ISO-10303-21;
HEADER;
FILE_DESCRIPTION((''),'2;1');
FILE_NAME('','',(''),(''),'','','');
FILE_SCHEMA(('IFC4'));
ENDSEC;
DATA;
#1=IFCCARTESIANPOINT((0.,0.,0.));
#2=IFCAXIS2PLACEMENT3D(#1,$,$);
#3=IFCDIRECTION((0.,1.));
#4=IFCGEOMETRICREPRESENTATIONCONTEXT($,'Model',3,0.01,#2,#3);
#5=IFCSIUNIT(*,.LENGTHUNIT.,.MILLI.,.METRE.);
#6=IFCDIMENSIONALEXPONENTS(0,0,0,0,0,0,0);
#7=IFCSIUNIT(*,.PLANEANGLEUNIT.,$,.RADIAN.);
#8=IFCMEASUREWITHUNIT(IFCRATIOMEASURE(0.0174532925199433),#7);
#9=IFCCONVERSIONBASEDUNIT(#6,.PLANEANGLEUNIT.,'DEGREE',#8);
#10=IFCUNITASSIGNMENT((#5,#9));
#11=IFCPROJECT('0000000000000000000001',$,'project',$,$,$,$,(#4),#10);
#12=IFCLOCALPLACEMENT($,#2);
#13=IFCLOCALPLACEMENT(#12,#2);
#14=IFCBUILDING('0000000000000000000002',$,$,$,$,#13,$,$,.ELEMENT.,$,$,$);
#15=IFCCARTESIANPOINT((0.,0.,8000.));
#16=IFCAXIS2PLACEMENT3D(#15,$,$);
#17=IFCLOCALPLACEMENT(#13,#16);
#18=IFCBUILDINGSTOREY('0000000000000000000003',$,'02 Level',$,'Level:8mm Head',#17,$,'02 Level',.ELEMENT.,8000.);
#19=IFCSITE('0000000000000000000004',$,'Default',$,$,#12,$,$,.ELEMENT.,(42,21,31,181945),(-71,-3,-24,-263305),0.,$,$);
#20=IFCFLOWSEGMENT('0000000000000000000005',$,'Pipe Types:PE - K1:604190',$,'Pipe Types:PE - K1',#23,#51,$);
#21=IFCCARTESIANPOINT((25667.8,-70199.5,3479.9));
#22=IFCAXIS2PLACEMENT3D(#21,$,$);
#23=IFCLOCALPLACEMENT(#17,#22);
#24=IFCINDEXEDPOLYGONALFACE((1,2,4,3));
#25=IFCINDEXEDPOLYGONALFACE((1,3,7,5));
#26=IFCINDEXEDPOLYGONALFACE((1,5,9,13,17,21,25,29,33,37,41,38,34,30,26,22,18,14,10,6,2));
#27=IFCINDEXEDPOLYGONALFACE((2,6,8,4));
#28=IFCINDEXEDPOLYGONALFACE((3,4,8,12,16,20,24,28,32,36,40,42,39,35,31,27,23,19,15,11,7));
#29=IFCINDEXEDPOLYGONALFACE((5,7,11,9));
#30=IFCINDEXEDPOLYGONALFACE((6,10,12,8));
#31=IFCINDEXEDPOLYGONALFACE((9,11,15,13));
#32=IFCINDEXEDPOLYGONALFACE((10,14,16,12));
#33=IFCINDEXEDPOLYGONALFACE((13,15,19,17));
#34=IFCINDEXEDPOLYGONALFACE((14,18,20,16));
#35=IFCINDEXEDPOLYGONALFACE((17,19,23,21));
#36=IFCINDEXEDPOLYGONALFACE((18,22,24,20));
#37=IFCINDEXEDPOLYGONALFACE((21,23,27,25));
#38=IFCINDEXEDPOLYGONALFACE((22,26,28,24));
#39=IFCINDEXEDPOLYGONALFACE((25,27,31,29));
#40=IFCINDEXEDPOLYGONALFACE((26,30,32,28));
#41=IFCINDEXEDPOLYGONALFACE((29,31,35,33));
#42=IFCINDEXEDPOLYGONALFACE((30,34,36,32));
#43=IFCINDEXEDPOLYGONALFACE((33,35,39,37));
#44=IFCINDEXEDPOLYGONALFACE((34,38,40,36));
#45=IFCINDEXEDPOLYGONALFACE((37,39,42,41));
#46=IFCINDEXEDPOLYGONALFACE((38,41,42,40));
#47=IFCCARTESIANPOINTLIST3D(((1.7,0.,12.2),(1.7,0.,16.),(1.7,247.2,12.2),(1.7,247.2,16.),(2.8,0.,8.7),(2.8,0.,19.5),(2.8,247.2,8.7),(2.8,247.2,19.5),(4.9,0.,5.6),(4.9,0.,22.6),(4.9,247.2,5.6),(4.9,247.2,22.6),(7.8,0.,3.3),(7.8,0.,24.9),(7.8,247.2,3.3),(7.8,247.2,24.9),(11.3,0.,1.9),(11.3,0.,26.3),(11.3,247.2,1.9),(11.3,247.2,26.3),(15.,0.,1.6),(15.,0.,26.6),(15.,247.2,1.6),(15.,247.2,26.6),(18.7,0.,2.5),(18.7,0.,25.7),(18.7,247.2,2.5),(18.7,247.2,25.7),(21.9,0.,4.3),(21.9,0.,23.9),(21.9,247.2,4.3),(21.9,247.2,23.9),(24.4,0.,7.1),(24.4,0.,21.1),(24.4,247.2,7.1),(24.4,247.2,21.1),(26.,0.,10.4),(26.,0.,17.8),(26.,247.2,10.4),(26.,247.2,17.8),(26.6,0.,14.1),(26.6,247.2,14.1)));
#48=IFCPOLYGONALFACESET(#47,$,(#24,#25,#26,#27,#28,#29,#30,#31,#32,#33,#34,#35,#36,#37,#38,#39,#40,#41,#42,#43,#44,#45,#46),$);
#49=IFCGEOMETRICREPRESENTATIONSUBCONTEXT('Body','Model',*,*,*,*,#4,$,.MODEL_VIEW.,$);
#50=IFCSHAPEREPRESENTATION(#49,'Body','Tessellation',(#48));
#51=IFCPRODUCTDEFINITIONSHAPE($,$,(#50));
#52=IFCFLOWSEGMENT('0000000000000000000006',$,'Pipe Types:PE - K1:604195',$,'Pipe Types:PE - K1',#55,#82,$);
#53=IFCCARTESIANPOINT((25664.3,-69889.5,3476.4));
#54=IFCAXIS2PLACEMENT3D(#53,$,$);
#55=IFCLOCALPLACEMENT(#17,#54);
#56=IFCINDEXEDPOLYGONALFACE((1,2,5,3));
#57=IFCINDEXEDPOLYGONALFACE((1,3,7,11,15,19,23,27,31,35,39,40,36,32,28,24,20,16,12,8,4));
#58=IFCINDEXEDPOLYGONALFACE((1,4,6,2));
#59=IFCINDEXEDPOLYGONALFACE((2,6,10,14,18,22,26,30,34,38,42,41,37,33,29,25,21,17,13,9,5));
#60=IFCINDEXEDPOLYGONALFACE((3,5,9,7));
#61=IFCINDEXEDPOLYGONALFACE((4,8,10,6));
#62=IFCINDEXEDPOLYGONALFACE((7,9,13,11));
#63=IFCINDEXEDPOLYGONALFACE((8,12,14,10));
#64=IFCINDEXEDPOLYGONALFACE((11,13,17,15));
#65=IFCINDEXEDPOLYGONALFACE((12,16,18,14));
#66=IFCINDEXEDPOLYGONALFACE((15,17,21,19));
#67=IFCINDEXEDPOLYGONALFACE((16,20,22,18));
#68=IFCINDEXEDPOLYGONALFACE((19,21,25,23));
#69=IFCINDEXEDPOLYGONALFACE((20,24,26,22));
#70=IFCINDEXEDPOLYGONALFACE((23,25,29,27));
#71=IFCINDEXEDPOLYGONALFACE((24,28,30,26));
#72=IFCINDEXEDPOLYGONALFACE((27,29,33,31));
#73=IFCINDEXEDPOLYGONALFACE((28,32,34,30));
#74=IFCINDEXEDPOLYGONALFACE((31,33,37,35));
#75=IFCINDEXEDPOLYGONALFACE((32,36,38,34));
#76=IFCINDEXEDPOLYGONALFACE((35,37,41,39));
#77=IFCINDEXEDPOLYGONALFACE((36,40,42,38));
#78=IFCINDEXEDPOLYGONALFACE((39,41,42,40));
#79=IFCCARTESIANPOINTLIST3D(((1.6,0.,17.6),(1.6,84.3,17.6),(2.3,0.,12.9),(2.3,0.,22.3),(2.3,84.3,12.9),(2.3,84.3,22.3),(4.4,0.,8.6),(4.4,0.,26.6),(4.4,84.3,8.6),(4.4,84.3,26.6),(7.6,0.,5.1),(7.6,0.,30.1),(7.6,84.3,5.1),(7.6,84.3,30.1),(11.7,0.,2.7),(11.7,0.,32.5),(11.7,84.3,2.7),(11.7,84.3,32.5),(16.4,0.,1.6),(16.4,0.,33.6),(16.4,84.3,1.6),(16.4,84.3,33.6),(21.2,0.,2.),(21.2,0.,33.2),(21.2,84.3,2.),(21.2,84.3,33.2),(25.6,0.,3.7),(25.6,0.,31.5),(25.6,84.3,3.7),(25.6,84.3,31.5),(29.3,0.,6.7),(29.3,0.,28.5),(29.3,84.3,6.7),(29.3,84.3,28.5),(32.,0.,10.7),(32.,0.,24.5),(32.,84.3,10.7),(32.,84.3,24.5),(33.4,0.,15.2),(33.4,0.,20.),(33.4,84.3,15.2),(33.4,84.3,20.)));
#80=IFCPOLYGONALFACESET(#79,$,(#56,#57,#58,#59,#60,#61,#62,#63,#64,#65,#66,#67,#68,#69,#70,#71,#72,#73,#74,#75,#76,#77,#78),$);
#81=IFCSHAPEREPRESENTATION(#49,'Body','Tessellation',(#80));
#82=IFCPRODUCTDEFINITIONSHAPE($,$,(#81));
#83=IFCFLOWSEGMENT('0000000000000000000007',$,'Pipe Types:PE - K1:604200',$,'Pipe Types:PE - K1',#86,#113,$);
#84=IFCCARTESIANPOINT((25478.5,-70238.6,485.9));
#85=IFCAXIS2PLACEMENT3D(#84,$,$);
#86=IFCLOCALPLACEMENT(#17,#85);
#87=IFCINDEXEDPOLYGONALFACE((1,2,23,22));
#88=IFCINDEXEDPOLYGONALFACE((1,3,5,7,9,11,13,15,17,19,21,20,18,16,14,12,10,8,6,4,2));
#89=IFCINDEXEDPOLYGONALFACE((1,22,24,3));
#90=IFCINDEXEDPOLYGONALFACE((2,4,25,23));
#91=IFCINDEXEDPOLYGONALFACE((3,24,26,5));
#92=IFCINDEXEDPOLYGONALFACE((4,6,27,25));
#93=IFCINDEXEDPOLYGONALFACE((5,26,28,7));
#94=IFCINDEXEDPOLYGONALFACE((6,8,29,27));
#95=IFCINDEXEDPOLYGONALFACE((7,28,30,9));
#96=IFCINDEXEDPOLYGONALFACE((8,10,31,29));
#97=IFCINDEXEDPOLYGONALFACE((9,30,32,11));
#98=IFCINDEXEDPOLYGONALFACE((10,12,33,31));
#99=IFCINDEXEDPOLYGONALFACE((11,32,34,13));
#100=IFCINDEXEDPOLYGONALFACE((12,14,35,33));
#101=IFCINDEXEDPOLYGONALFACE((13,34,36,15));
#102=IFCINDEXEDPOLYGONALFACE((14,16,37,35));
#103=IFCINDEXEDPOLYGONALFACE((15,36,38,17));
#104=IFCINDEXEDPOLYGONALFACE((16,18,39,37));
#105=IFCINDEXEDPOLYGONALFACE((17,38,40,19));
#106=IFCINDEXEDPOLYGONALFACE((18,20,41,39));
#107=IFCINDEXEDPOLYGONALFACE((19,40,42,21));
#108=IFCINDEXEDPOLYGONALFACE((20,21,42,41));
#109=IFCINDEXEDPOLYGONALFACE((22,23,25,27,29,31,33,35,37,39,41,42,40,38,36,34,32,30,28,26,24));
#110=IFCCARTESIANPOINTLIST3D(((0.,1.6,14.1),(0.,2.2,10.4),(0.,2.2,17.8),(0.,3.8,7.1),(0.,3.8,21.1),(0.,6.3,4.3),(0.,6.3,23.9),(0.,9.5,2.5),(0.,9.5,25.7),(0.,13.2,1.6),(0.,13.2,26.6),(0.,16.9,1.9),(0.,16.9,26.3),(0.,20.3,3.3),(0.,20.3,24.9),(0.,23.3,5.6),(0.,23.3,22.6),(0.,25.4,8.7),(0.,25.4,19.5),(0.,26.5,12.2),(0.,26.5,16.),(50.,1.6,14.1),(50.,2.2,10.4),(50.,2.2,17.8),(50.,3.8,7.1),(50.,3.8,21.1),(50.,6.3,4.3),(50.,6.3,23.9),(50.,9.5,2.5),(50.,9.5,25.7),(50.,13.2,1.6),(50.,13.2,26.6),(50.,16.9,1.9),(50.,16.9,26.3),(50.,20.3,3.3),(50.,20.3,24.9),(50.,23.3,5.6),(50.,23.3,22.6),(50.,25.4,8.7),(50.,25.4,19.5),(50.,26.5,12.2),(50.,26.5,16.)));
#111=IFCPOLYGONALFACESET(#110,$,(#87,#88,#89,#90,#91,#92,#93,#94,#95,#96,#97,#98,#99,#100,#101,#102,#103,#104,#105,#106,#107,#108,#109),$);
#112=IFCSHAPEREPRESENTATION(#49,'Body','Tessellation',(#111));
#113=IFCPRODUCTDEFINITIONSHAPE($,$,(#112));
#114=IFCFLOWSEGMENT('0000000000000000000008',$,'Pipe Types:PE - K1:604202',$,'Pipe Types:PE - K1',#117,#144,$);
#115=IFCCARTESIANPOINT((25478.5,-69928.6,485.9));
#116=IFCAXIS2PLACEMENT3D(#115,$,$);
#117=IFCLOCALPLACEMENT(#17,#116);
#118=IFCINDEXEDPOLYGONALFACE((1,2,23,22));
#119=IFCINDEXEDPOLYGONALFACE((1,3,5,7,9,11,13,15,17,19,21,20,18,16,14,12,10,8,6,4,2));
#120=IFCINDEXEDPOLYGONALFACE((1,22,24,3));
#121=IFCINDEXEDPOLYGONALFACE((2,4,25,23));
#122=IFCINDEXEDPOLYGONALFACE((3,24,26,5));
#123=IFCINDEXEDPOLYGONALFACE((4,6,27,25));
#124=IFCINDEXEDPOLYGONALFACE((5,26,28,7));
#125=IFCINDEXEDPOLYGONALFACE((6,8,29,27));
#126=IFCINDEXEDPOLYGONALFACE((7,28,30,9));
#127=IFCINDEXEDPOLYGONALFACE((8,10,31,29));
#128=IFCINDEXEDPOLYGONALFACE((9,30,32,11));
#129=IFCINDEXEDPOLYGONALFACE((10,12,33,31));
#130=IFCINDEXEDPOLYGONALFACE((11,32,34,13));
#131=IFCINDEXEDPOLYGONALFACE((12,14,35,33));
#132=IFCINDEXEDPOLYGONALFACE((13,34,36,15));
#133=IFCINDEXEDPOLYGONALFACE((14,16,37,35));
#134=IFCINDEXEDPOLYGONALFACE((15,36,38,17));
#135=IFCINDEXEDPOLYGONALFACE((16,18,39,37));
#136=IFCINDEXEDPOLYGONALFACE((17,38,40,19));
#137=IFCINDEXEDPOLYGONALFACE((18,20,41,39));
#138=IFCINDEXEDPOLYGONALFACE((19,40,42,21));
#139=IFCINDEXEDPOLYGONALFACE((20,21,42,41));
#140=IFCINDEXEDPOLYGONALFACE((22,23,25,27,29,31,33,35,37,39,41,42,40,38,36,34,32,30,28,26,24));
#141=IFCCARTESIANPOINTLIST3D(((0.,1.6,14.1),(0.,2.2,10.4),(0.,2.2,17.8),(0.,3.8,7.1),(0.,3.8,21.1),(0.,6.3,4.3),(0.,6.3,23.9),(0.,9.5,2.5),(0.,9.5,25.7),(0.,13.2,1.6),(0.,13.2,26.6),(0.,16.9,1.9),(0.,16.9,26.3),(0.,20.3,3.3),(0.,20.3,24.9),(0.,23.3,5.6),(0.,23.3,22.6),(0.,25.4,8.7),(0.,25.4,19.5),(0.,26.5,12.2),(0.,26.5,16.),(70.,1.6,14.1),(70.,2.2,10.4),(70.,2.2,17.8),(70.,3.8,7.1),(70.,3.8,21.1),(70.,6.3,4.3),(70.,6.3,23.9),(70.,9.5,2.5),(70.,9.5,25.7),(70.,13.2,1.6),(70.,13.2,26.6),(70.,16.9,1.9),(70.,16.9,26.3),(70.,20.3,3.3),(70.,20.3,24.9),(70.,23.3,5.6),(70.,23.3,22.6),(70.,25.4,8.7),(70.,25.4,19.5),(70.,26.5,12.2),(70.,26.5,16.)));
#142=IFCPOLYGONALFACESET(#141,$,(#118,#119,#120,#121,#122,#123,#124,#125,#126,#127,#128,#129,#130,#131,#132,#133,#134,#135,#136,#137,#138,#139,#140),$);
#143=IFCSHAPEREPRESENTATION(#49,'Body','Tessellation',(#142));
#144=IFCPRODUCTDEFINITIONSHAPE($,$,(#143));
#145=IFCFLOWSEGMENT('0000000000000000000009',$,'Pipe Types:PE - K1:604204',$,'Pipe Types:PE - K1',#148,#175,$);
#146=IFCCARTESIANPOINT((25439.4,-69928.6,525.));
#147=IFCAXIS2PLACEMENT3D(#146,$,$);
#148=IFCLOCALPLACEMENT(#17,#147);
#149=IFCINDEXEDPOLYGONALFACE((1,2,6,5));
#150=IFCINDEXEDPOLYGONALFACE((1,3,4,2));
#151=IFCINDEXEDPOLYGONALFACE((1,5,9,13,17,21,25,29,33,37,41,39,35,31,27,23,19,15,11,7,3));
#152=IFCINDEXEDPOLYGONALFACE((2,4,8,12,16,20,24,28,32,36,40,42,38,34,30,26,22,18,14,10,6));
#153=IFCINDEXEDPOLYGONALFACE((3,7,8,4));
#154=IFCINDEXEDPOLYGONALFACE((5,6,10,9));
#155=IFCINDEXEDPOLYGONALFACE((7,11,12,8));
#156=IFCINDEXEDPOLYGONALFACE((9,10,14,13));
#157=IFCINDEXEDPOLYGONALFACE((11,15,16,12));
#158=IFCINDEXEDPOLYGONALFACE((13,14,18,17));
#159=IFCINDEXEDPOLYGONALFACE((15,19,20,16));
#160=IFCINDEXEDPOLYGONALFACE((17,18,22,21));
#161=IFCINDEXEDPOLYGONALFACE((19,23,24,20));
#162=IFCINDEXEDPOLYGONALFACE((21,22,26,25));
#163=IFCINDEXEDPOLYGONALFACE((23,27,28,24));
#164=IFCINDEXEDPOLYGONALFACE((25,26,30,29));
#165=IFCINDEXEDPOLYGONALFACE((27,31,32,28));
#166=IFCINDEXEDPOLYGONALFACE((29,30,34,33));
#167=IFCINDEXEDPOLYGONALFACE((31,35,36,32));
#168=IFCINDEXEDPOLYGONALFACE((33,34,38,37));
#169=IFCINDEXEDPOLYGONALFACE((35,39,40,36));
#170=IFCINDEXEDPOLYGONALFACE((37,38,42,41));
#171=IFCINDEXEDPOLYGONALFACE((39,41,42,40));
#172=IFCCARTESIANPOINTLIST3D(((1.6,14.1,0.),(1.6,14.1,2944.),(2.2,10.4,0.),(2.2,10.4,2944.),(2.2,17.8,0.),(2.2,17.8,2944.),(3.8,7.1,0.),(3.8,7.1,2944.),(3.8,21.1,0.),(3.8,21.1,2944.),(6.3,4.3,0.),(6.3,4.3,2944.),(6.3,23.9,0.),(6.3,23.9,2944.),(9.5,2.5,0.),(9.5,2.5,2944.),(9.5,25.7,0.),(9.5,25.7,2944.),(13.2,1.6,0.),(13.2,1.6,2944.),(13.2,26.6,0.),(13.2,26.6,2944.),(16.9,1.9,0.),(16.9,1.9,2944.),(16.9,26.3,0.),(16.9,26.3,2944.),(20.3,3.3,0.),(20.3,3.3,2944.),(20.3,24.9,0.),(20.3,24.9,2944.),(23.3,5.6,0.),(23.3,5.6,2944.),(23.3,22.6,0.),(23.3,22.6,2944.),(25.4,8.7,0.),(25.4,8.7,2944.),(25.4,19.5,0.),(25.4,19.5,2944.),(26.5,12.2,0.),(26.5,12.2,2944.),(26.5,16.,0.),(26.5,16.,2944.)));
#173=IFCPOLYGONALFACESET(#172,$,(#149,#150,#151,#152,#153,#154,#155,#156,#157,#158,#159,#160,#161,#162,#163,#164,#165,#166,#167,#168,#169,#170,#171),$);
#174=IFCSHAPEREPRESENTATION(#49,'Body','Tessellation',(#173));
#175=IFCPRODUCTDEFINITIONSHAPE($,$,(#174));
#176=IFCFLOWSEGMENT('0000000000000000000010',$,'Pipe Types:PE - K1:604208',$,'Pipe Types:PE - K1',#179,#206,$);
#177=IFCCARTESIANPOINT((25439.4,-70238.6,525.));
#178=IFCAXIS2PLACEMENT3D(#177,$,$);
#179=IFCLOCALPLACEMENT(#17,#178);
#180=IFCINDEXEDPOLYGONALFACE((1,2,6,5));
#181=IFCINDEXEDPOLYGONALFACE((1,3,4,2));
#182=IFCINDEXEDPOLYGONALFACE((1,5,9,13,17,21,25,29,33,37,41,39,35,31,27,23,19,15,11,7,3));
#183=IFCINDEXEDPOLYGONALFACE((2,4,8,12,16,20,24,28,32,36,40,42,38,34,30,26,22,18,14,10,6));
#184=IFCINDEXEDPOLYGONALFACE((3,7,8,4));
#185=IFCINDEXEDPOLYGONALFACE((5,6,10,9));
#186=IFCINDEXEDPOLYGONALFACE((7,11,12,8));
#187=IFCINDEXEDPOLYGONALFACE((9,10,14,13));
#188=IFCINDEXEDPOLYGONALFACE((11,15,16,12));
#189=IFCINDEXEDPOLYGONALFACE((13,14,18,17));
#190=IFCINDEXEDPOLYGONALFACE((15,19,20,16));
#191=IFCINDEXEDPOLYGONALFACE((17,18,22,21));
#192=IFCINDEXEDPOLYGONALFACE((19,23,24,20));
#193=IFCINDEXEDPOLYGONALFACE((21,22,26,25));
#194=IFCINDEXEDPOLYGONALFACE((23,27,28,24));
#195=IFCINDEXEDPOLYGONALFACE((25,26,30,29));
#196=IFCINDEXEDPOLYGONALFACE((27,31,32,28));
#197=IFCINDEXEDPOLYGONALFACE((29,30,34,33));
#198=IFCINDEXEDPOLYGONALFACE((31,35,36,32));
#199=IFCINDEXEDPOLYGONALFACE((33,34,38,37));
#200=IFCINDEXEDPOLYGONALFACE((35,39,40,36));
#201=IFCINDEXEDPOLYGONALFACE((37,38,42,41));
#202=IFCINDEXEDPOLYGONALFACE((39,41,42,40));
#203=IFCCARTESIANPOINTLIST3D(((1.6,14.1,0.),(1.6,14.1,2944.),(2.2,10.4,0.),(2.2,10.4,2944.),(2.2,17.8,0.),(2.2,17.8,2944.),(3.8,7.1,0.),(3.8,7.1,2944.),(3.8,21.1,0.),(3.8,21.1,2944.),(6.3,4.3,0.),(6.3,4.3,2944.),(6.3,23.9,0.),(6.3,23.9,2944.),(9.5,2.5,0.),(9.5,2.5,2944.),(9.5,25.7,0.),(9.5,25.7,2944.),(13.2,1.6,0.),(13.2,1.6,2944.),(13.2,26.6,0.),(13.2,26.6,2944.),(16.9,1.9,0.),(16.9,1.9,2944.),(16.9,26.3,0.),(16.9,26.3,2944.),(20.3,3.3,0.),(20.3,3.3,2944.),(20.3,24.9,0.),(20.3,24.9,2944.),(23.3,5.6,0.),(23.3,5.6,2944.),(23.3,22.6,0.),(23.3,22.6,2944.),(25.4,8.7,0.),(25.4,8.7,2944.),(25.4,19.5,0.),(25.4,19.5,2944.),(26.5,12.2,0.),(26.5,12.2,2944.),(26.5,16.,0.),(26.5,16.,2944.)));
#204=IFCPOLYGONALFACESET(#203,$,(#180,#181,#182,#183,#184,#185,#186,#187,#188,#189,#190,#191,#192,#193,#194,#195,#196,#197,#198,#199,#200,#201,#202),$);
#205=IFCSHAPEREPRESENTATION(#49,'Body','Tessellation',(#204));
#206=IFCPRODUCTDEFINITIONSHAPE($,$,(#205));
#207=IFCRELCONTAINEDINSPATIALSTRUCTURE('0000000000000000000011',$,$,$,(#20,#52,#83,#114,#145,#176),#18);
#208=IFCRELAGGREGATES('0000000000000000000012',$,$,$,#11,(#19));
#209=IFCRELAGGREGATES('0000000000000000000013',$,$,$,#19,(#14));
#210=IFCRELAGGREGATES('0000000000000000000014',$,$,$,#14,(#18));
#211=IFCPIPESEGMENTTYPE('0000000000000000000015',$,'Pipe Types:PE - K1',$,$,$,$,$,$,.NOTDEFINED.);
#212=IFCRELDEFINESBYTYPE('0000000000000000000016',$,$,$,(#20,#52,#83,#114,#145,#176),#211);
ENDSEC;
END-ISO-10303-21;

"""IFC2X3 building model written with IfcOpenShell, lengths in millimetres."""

from ifc_helpers import new_model, entity, si_unit, converted_unit, direction, frame, frame_2d, origin, origin_2d_with_axis, place, context, subcontext, project, spatial, circle, extrude, type_object, element, save


model = new_model("IFC2X3")

# Units and contexts
model_context = context("Model", 3, precision=0.01, world=origin(), true_north=direction((0.0, 1.0)))
body_context = subcontext(model_context, "Body", "Model", "MODEL_VIEW")
ifc_project = project(units=[si_unit("LENGTHUNIT", "METRE", prefix="MILLI"), converted_unit("PLANEANGLEUNIT", "DEGREE", entity("IfcRatioMeasure", 0.0174532925199433), si_unit("PLANEANGLEUNIT", "RADIAN"), dimensions=[0, 0, 0, 0, 0, 0, 0])], contexts=[model_context])

# Site, building, storey
site_placement = place(None, origin())
site = spatial("IfcSite", under=ifc_project, at=site_placement, Name="Default", CompositionType="ELEMENT", RefLatitude=(42, 21, 31, 181945), RefLongitude=(-71, -3, -24, -263305), RefElevation=0.0)
building_placement = place(site_placement, origin())
building = spatial("IfcBuilding", under=site, at=building_placement, CompositionType="ELEMENT")
storey_placement = place(building_placement, frame((0.0, 0.0, 8000.0)))
storey = spatial("IfcBuildingStorey", under=building, at=storey_placement, Name="02 Level", ObjectType="Level:8mm Head", LongName="02 Level", CompositionType="ELEMENT", Elevation=8000.0)

# Flow segments
pipe_segment_type = type_object("IfcPipeSegmentType", Name="Pipe Types:PE - K1", PredefinedType="NOTDEFINED")
flow_segment_1_placement = place(storey_placement, frame((25667.8, -70199.5, 3479.9)))
element("IfcFlowSegment", 1, at=flow_segment_1_placement, inside=storey, type_object=pipe_segment_type, Name="Pipe Types:PE - K1:604190", ObjectType="Pipe Types:PE - K1", context=body_context, shape_type="SweptSolid", body=[
    extrude(circle(Radius=12.5, at=origin_2d_with_axis()), frame((14.1, 0.0, 14.1), z_axis=(0.0, 1.0, 0.0), x_axis=(1.0, 0.0, 0.0)), (0.0, 0.0, 1.0), 247.2),
])
flow_segment_2_placement = place(storey_placement, frame((25664.3, -69889.5, 3476.4)))
element("IfcFlowSegment", 2, at=flow_segment_2_placement, inside=storey, type_object=pipe_segment_type, Name="Pipe Types:PE - K1:604195", ObjectType="Pipe Types:PE - K1", context=body_context, shape_type="SweptSolid", body=[
    extrude(circle(Radius=16.0, at=origin_2d_with_axis()), frame((17.6, 0.0, 17.6), z_axis=(0.0, 1.0, 0.0), x_axis=(-1.0, 0.0, 0.0)), (0.0, 0.0, 1.0), 84.3),
])
flow_segment_3_placement = place(storey_placement, frame((25478.5, -70238.6, 485.9)))
element("IfcFlowSegment", 3, at=flow_segment_3_placement, inside=storey, type_object=pipe_segment_type, Name="Pipe Types:PE - K1:604200", ObjectType="Pipe Types:PE - K1", context=body_context, shape_type="SweptSolid", body=[
    extrude(circle(Radius=12.5, at=frame_2d((0.0, 0.0), x_axis=(1.0, 0.0))), frame((0.0, 14.1, 14.1), z_axis=(1.0, 0.0, 0.0), x_axis=(0.0, -1.0, 0.0)), (0.0, 0.0, 1.0), 50.0),
])
flow_segment_4_placement = place(storey_placement, frame((25478.5, -69928.6, 485.9)))
element("IfcFlowSegment", 4, at=flow_segment_4_placement, inside=storey, type_object=pipe_segment_type, Name="Pipe Types:PE - K1:604202", ObjectType="Pipe Types:PE - K1", context=body_context, shape_type="SweptSolid", body=[
    extrude(circle(Radius=12.5, at=frame_2d((0.0, 0.0), x_axis=(1.0, 0.0))), frame((0.0, 14.1, 14.1), z_axis=(1.0, 0.0, 0.0), x_axis=(0.0, -1.0, 0.0)), (0.0, 0.0, 1.0), 70.0),
])
flow_segment_5_placement = place(storey_placement, frame((25439.4, -69928.6, 525.0)))
element("IfcFlowSegment", 5, at=flow_segment_5_placement, inside=storey, type_object=pipe_segment_type, Name="Pipe Types:PE - K1:604204", ObjectType="Pipe Types:PE - K1", context=body_context, shape_type="SweptSolid", body=[
    extrude(circle(Radius=12.5, at=frame_2d((0.0, 0.0), x_axis=(1.0, 0.0))), frame((14.1, 14.1, 0.0), z_axis=(0.0, 0.0, 1.0), x_axis=(-1.0, 0.0, 0.0)), (0.0, 0.0, 1.0), 2944.0),
])
flow_segment_6_placement = place(storey_placement, frame((25439.4, -70238.6, 525.0)))
element("IfcFlowSegment", 6, at=flow_segment_6_placement, inside=storey, type_object=pipe_segment_type, Name="Pipe Types:PE - K1:604208", ObjectType="Pipe Types:PE - K1", context=body_context, shape_type="SweptSolid", body=[
    extrude(circle(Radius=12.5, at=origin_2d_with_axis()), frame((14.1, 14.1, 0.0), z_axis=(0.0, 0.0, 1.0), x_axis=(-1.0, 0.0, 0.0)), (0.0, 0.0, 1.0), 2944.0),
])

save(model, "model.ifc")
